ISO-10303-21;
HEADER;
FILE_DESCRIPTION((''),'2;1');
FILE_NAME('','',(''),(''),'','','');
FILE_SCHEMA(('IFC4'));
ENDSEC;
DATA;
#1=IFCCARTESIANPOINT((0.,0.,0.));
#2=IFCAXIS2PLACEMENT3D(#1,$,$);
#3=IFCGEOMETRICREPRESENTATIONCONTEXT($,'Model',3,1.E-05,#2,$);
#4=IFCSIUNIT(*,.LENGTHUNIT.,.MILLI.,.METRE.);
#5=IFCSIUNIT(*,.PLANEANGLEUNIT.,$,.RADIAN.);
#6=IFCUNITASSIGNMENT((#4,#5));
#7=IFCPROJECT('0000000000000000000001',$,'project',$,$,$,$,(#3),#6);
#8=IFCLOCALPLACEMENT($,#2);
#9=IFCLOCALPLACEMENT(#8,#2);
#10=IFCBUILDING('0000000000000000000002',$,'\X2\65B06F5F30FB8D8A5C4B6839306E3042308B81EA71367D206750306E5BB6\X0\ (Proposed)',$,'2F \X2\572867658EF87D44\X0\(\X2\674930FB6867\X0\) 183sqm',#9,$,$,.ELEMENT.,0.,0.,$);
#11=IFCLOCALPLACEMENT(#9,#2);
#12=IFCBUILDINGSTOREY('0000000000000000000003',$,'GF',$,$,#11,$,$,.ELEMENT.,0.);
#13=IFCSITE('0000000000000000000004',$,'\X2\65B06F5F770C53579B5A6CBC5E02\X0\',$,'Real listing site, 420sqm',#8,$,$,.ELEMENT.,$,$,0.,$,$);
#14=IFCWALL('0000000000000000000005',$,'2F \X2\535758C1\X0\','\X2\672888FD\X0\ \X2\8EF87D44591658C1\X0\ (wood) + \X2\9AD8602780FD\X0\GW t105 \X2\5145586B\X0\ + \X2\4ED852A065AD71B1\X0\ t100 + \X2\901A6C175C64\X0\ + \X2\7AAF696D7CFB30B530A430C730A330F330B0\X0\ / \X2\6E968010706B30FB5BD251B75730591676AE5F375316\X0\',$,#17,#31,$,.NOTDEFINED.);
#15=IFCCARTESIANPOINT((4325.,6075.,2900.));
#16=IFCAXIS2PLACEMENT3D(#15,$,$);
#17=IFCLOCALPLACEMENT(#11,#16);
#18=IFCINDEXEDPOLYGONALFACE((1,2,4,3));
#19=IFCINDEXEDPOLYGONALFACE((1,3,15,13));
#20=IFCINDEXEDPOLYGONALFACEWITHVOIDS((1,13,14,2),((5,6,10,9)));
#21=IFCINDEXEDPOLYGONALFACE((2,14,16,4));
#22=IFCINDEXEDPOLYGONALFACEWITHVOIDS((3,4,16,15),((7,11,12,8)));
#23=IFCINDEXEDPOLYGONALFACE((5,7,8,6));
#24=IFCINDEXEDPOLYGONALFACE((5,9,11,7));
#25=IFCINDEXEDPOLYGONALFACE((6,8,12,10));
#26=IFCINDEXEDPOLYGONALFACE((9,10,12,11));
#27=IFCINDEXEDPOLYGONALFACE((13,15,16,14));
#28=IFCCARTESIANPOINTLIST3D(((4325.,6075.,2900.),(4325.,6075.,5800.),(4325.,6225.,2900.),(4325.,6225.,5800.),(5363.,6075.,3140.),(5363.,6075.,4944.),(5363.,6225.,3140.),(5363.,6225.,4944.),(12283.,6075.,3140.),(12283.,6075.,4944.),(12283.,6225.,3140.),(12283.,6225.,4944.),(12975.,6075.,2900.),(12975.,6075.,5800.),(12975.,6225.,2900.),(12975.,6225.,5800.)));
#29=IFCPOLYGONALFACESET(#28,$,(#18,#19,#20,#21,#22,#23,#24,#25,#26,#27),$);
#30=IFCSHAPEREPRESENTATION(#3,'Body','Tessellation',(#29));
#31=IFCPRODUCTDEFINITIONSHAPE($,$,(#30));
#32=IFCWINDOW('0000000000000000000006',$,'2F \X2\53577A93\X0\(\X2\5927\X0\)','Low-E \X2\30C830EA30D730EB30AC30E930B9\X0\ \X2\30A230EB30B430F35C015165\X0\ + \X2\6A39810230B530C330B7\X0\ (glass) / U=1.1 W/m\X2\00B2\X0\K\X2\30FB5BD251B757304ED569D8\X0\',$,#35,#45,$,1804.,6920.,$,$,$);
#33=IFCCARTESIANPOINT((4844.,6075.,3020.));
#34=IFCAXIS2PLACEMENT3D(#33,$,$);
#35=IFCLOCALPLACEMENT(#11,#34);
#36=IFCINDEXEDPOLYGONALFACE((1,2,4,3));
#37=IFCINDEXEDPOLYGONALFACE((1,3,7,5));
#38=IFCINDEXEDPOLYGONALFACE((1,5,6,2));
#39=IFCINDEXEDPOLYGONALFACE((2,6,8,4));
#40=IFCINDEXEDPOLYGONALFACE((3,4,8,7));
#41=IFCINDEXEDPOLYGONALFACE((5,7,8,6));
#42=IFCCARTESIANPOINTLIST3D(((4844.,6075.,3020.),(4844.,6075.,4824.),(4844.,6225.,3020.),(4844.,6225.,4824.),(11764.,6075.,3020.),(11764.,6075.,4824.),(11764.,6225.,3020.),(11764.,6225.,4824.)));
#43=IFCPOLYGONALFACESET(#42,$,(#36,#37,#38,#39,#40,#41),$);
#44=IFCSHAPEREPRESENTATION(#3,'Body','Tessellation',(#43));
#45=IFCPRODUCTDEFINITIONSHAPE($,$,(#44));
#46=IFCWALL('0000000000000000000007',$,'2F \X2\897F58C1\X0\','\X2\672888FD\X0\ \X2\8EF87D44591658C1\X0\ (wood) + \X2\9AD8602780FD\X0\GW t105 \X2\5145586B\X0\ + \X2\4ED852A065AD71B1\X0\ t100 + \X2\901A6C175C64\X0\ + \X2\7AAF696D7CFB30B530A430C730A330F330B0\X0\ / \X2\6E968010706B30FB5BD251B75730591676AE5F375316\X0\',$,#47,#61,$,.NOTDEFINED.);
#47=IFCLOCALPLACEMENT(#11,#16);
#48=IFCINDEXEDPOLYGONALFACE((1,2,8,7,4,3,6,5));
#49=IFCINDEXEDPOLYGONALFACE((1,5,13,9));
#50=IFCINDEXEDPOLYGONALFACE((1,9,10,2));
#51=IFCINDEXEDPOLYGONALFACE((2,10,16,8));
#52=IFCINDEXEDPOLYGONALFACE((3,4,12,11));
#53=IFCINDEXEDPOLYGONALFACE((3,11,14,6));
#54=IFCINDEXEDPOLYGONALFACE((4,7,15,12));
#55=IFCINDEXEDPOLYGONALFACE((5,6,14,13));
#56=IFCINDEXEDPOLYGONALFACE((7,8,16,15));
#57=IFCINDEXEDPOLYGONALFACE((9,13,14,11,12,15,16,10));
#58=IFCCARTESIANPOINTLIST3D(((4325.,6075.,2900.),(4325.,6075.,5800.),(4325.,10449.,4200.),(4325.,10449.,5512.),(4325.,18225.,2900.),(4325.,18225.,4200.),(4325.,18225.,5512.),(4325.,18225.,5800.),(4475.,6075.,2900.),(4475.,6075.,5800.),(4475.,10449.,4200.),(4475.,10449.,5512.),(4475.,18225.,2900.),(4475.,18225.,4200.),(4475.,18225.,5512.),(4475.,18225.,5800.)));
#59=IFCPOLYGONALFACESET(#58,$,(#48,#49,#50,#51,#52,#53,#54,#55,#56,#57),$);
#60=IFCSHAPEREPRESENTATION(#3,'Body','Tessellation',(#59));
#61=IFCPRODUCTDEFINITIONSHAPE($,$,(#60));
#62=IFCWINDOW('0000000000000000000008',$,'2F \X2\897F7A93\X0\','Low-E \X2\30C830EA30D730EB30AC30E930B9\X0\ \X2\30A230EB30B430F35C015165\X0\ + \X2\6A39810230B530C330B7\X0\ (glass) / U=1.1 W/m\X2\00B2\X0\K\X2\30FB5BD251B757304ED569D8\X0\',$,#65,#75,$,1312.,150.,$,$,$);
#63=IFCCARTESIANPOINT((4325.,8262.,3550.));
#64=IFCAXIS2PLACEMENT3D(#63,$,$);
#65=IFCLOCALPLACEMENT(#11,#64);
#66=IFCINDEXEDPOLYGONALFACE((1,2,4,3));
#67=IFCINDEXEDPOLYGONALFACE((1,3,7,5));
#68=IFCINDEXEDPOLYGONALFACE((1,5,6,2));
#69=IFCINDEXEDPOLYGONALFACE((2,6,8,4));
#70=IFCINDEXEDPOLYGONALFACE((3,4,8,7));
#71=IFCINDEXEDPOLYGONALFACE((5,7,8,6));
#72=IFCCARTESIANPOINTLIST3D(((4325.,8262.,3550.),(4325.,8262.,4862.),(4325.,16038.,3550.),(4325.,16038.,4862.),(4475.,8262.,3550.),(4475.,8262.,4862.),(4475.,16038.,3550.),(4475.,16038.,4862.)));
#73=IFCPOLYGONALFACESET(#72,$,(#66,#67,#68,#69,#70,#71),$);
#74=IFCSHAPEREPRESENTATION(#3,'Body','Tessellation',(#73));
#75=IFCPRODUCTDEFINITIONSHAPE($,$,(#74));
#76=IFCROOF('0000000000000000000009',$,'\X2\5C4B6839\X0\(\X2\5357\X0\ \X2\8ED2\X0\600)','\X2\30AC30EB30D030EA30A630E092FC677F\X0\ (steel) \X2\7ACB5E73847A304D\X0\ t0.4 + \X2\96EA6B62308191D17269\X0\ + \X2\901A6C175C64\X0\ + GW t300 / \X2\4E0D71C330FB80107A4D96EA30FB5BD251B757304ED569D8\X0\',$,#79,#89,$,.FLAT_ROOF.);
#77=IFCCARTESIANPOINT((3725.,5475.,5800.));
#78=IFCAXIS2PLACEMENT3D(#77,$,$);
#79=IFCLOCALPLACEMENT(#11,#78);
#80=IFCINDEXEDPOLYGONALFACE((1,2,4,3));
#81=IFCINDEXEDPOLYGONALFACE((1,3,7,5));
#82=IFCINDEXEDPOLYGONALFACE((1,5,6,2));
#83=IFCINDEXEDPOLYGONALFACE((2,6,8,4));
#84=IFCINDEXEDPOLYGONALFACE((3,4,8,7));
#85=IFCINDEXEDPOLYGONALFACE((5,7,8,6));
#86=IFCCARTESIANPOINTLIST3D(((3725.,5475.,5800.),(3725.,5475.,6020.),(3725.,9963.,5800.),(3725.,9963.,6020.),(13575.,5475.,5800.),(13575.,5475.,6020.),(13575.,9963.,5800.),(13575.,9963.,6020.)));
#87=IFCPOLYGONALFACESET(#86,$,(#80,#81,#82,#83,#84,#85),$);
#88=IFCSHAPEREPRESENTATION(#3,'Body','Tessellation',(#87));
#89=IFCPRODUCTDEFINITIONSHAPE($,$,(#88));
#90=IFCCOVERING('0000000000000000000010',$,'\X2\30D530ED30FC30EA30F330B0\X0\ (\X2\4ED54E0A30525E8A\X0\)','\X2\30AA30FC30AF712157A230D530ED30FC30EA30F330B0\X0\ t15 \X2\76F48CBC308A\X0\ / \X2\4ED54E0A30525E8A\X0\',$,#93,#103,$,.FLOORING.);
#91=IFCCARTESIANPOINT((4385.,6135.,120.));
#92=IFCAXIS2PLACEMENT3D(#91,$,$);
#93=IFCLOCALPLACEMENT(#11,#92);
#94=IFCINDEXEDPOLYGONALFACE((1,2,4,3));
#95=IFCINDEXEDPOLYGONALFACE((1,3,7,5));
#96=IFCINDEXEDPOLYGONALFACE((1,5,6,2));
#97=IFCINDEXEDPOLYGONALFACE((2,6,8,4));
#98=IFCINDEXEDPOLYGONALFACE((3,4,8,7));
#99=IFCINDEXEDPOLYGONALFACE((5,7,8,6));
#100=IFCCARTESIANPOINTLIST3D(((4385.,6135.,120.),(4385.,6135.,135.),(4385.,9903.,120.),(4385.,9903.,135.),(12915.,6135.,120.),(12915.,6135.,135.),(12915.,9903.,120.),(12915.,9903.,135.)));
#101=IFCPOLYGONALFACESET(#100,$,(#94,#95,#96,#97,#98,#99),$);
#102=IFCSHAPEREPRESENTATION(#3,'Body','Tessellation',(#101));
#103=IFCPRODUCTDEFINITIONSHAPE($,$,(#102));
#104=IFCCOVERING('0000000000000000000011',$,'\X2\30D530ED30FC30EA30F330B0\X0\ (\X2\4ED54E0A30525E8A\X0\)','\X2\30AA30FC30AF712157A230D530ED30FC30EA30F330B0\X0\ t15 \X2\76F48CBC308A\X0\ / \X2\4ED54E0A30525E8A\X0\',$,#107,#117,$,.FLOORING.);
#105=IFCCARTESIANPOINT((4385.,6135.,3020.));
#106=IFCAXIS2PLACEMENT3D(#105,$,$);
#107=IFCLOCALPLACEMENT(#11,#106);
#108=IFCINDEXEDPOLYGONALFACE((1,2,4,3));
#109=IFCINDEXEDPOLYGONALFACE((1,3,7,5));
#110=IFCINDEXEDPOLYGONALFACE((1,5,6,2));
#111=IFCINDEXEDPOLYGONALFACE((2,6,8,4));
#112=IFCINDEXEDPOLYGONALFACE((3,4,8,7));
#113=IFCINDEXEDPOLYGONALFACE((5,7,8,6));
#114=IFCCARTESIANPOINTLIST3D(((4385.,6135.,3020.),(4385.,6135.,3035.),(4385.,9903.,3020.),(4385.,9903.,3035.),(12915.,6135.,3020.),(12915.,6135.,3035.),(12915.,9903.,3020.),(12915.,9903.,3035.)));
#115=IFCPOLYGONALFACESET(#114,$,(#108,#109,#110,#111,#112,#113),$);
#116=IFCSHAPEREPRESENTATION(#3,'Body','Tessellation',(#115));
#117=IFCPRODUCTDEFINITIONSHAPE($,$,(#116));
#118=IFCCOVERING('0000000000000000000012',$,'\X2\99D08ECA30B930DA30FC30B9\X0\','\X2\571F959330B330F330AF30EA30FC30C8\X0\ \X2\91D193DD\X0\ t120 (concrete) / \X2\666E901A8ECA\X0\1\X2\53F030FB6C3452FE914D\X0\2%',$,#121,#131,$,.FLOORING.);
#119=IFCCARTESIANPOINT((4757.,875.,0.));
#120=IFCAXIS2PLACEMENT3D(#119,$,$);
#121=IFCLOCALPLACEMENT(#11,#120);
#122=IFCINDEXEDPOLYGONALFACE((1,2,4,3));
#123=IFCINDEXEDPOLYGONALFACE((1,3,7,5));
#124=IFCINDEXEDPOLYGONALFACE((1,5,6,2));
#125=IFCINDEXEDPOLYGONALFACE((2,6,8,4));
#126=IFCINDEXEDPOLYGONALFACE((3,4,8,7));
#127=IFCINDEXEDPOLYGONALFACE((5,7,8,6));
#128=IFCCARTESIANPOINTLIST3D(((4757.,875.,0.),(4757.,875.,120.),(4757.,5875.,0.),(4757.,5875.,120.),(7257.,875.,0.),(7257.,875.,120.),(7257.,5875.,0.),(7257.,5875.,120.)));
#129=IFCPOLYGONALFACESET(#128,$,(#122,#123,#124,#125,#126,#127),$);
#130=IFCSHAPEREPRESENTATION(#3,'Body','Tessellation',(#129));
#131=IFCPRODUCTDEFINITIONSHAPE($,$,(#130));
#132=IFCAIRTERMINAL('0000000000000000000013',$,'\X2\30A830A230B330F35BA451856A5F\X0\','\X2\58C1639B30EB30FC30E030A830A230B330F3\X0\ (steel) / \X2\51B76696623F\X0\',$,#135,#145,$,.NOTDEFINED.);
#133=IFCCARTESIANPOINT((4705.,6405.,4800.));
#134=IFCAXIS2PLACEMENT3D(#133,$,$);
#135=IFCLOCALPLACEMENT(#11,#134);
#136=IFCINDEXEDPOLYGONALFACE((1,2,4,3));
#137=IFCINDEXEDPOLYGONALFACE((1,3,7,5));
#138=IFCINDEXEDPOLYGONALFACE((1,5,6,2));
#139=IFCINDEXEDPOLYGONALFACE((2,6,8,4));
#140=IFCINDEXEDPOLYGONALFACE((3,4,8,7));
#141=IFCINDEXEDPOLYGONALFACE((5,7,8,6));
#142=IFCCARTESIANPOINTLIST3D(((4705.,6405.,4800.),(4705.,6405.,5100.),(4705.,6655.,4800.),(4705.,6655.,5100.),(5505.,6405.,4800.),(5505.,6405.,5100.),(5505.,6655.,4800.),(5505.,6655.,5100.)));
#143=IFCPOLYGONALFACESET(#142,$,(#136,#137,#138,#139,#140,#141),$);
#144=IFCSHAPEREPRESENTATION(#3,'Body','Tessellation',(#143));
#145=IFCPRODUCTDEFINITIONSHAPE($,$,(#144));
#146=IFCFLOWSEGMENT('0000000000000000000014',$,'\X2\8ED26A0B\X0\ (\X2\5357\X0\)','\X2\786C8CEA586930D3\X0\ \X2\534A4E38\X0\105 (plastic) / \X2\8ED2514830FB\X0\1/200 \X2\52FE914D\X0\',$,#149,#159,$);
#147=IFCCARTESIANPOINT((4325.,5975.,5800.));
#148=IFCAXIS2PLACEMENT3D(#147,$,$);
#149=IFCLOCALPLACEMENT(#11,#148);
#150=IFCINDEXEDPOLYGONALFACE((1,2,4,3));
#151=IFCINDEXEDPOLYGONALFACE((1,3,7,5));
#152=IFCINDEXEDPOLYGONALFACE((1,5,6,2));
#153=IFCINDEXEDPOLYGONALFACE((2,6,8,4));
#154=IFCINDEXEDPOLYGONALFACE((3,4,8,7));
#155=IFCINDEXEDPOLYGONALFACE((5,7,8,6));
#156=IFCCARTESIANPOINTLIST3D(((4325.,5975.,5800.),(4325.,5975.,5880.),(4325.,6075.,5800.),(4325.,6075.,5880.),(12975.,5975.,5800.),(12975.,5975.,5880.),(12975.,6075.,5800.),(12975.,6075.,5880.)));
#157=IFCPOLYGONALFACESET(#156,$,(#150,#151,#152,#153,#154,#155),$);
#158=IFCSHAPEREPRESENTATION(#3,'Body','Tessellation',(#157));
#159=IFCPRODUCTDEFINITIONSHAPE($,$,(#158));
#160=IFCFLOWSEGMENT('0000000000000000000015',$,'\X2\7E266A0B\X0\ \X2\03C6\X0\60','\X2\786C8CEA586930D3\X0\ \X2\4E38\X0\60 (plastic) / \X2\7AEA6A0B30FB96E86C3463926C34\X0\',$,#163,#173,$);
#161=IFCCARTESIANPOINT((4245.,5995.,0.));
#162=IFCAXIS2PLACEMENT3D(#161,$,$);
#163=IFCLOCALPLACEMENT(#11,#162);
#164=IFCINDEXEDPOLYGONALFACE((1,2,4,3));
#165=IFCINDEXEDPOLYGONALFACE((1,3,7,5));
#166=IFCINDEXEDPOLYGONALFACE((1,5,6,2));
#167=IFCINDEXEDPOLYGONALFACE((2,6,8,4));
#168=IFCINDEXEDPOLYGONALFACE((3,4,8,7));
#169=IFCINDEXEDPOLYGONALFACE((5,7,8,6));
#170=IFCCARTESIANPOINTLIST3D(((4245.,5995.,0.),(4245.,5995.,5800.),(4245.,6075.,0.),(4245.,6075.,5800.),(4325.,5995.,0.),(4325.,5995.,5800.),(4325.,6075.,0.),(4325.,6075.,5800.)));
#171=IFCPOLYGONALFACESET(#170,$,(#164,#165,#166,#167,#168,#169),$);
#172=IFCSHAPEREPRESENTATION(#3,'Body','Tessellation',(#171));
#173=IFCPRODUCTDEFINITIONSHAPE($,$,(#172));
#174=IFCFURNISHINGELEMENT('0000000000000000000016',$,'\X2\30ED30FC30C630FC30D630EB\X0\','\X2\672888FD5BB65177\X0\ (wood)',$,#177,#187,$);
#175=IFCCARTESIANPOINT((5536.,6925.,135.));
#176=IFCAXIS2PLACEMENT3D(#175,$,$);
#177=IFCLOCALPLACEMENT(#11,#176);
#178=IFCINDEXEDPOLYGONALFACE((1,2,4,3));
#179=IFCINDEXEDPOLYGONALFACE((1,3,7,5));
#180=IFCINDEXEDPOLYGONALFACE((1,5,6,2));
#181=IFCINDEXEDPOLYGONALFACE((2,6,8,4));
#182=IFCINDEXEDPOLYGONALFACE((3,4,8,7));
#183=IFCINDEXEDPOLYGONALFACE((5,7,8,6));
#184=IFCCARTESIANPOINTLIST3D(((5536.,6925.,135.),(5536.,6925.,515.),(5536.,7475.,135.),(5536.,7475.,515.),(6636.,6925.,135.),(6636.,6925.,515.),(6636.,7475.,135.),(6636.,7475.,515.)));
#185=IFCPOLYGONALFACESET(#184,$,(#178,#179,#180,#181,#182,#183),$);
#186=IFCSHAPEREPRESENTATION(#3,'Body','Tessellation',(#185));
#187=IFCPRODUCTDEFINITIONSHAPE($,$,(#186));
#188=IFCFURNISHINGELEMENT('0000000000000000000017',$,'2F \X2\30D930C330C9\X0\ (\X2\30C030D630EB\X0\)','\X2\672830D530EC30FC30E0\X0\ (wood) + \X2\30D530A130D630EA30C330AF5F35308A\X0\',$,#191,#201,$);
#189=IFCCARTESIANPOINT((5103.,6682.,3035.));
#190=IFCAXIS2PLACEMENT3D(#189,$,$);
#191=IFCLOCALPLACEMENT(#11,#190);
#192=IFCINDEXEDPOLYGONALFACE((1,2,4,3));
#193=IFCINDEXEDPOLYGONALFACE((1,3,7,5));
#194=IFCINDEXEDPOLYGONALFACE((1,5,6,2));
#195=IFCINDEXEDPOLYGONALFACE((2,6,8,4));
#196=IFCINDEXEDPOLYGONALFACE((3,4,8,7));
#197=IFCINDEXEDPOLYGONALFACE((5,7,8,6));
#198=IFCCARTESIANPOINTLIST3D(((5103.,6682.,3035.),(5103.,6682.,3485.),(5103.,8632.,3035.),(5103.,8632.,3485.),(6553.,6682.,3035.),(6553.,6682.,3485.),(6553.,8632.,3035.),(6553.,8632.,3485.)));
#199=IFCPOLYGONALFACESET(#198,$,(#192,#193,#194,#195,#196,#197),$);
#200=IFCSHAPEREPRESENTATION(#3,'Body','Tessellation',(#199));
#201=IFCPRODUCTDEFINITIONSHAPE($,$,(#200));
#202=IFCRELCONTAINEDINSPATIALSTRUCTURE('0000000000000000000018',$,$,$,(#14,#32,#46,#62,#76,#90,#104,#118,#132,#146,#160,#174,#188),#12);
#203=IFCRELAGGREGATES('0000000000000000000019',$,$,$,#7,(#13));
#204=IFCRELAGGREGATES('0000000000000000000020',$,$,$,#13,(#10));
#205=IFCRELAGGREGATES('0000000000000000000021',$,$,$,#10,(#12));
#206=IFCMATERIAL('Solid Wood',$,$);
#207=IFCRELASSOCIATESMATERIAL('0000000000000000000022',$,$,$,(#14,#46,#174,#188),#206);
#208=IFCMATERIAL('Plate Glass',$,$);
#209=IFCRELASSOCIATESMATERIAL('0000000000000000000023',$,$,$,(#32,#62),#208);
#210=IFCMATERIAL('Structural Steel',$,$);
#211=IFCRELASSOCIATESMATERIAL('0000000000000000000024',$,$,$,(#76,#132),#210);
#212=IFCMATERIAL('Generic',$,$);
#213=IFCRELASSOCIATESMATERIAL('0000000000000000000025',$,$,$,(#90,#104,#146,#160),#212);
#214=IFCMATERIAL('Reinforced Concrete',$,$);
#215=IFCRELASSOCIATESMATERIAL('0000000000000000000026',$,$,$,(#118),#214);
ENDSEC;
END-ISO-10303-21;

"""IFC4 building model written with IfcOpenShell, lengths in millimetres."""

from ifc_helpers import new_model, si_unit, frame, frame_2d, origin, place, context, project, spatial, rectangle, extrude, material, element, fill, save


model = new_model("IFC4")

# Units and contexts
model_context = context("Model", 3, precision=1e-05, world=origin())
ifc_project = project(units=[si_unit("LENGTHUNIT", "METRE", prefix="MILLI"), si_unit("PLANEANGLEUNIT", "RADIAN")], contexts=[model_context])

# Site, building, storey
site_placement = place(None, origin())
site = spatial("IfcSite", under=ifc_project, at=site_placement, Name="新潟県南魚沼市", ObjectType="Real listing site, 420sqm", CompositionType="ELEMENT", RefElevation=0.0)
building_placement = place(site_placement, origin())
building = spatial("IfcBuilding", under=site, at=building_placement, Name="新潟・越屋根のある自然素材の家 (Proposed)", ObjectType="2F 在来軸組(杉・桧) 183sqm", CompositionType="ELEMENT", ElevationOfRefHeight=0.0, ElevationOfTerrain=0.0)
storey_placement = place(building_placement, origin())
storey = spatial("IfcBuildingStorey", under=building, at=storey_placement, Name="GF", CompositionType="ELEMENT", Elevation=0.0)

# Shared definitions
ifc_material_1 = material(Name="Solid Wood")

# Shared definitions
ifc_material_2 = material(Name="Reinforced Concrete")

# Shared definitions
ifc_material_3 = material(Name="Plate Glass")

# Walls, openings, windows
wall_1_placement = place(storey_placement, frame((4325.0, 6075.0, 2900.0)))
wall_1 = element("IfcWall", 1, at=wall_1_placement, inside=storey, material=ifc_material_1, Name="2F 南壁", Description="木製 軸組外壁 (wood) + 高性能GW t105 充填 + 付加断熱 t100 + 通気層 + 窯業系サイディング / 準耐火・寒冷地外皮強化", PredefinedType="NOTDEFINED", context=model_context, shape_type="SweptSolid", body=[
    extrude(rectangle(XDim=8650.0, YDim=150.0, at=frame_2d((4325.0, 75.0))), frame((4325.0, 6075.0, 2900.0)), (0.0, 0.0, 1.0), 2900.0),
])
opening_1_placement = place(storey_placement, frame((4844.0, 6075.0, 3020.0)))
opening_1 = element("IfcOpeningElement", 2, at=opening_1_placement, cuts=wall_1, PredefinedType="NOTDEFINED", context=model_context, shape_type="SweptSolid", body=[
    extrude(rectangle(XDim=6920.0, YDim=150.0, at=frame_2d((3460.0, 75.0))), frame((4844.0, 6075.0, 3020.0)), (0.0, 0.0, 1.0), 1804.0),
])
window_1_placement = place(storey_placement, frame((4844.0, 6075.0, 3020.0)))
window_1 = element("IfcWindow", 3, at=window_1_placement, inside=storey, material=ifc_material_3, Name="2F 南窓(大)", Description="Low-E トリプルガラス アルゴン封入 + 樹脂サッシ (glass) / U=1.1 W/m²K・寒冷地仕様", OverallHeight=1804.0, OverallWidth=6920.0, context=model_context, shape_type="SweptSolid", body=[
    extrude(rectangle(XDim=6920.0, YDim=150.0, at=frame_2d((3460.0, 75.0))), frame((4844.0, 6075.0, 3020.0)), (0.0, 0.0, 1.0), 1804.0),
])
fill(opening_1, window_1)
wall_2_placement = place(storey_placement, frame((4325.0, 6075.0, 2900.0)))
wall_2 = element("IfcWall", 4, at=wall_2_placement, inside=storey, material=ifc_material_1, Name="2F 西壁", Description="木製 軸組外壁 (wood) + 高性能GW t105 充填 + 付加断熱 t100 + 通気層 + 窯業系サイディング / 準耐火・寒冷地外皮強化", PredefinedType="NOTDEFINED", context=model_context, shape_type="SweptSolid", body=[
    extrude(rectangle(XDim=150.0, YDim=12150.0, at=frame_2d((75.0, 6075.0))), frame((4325.0, 6075.0, 2900.0)), (0.0, 0.0, 1.0), 2900.0),
])
opening_2_placement = place(storey_placement, frame((4325.0, 8262.0, 3550.0)))
opening_2 = element("IfcOpeningElement", 5, at=opening_2_placement, cuts=wall_2, PredefinedType="NOTDEFINED", context=model_context, shape_type="SweptSolid", body=[
    extrude(rectangle(XDim=150.0, YDim=7776.0, at=frame_2d((75.0, 3888.0))), frame((4325.0, 8262.0, 3550.0)), (0.0, 0.0, 1.0), 1312.0),
])
window_2_placement = place(storey_placement, frame((4325.0, 8262.0, 3550.0)))
window_2 = element("IfcWindow", 6, at=window_2_placement, inside=storey, material=ifc_material_3, Name="2F 西窓", Description="Low-E トリプルガラス アルゴン封入 + 樹脂サッシ (glass) / U=1.1 W/m²K・寒冷地仕様", OverallHeight=1312.0, OverallWidth=150.0, context=model_context, shape_type="SweptSolid", body=[
    extrude(rectangle(XDim=150.0, YDim=7776.0, at=frame_2d((75.0, 3888.0))), frame((4325.0, 8262.0, 3550.0)), (0.0, 0.0, 1.0), 1312.0),
])
fill(opening_2, window_2)

# Roof
ifc_material_4 = material(Name="Structural Steel")
for number, where, name in (
    (7, (3725.0, 5475.0, 5800.0), "屋根(南 軒600)"),
):
    element("IfcRoof", number, at=place(storey_placement, frame(where)), inside=storey, material=ifc_material_4, Name=name, Description="ガルバリウム鋼板 (steel) 立平葺き t0.4 + 雪止め金物 + 通気層 + GW t300 / 不燃・耐積雪・寒冷地仕様", PredefinedType="FLAT_ROOF", context=model_context, shape_type="SweptSolid", body=[
        extrude(rectangle(XDim=9850.0, YDim=4488.0, at=frame_2d((4925.0, 2244.0))), frame((3725.0, 5475.0, 5800.0)), (0.0, 0.0, 1.0), 220.0),
    ])

# Coverings
ifc_material_5 = material(Name="Generic")
covering_1_placement = place(storey_placement, frame((4385.0, 6135.0, 120.0)))
element("IfcCovering", 8, at=covering_1_placement, inside=storey, material=ifc_material_5, Name="フローリング (仕上げ床)", Description="オーク無垢フローリング t15 直貼り / 仕上げ床", PredefinedType="FLOORING", context=model_context, shape_type="SweptSolid", body=[
    extrude(rectangle(XDim=8530.0, YDim=3768.0, at=frame_2d((4265.0, 1884.0))), frame((4385.0, 6135.0, 120.0)), (0.0, 0.0, 1.0), 15.0),
])
covering_2_placement = place(storey_placement, frame((4385.0, 6135.0, 3020.0)))
element("IfcCovering", 9, at=covering_2_placement, inside=storey, material=ifc_material_5, Name="フローリング (仕上げ床)", Description="オーク無垢フローリング t15 直貼り / 仕上げ床", PredefinedType="FLOORING", context=model_context, shape_type="SweptSolid", body=[
    extrude(rectangle(XDim=8530.0, YDim=3768.0, at=frame_2d((4265.0, 1884.0))), frame((4385.0, 6135.0, 3020.0)), (0.0, 0.0, 1.0), 15.0),
])
covering_3_placement = place(storey_placement, frame((4757.0, 875.0, 0.0)))
element("IfcCovering", 10, at=covering_3_placement, inside=storey, material=ifc_material_2, Name="駐車スペース", Description="土間コンクリート 金鏝 t120 (concrete) / 普通車1台・水勾配2%", PredefinedType="FLOORING", context=model_context, shape_type="SweptSolid", body=[
    extrude(rectangle(XDim=2500.0, YDim=5000.0, at=frame_2d((1250.0, 2500.0))), frame((4757.0, 875.0, 0.0)), (0.0, 0.0, 1.0), 120.0),
])

# Air terminal
air_terminal_placement = place(storey_placement, frame((4705.0, 6405.0, 4800.0)))
element("IfcAirTerminal", 11, at=air_terminal_placement, inside=storey, material=ifc_material_4, Name="エアコン室内機", Description="壁掛ルームエアコン (steel) / 冷暖房", PredefinedType="NOTDEFINED", context=model_context, shape_type="SweptSolid", body=[
    extrude(rectangle(XDim=800.0, YDim=250.0, at=frame_2d((400.0, 125.0))), frame((4705.0, 6405.0, 4800.0)), (0.0, 0.0, 1.0), 300.0),
])

# Flow segments
flow_segment_1_placement = place(storey_placement, frame((4325.0, 5975.0, 5800.0)))
element("IfcFlowSegment", 12, at=flow_segment_1_placement, inside=storey, material=ifc_material_5, Name="軒樋 (南)", Description="硬質塩ビ 半丸105 (plastic) / 軒先・1/200 勾配", context=model_context, shape_type="SweptSolid", body=[
    extrude(rectangle(XDim=8650.0, YDim=100.0, at=frame_2d((4325.0, 50.0))), frame((4325.0, 5975.0, 5800.0)), (0.0, 0.0, 1.0), 80.0),
])
flow_segment_2_placement = place(storey_placement, frame((4245.0, 5995.0, 0.0)))
element("IfcFlowSegment", 13, at=flow_segment_2_placement, inside=storey, material=ifc_material_5, Name="縦樋 φ60", Description="硬質塩ビ 丸60 (plastic) / 竪樋・雨水排水", context=model_context, shape_type="SweptSolid", body=[
    extrude(rectangle(XDim=80.0, YDim=80.0, at=frame_2d((40.0, 40.0))), frame((4245.0, 5995.0, 0.0)), (0.0, 0.0, 1.0), 5800.0),
])

# Furnishing elements
furnishing_1_placement = place(storey_placement, frame((5536.0, 6925.0, 135.0)))
element("IfcFurnishingElement", 14, at=furnishing_1_placement, inside=storey, material=ifc_material_1, Name="ローテーブル", Description="木製家具 (wood)", context=model_context, shape_type="SweptSolid", body=[
    extrude(rectangle(XDim=1100.0, YDim=550.0, at=frame_2d((550.0, 275.0))), frame((5536.0, 6925.0, 135.0)), (0.0, 0.0, 1.0), 380.0),
])
furnishing_2_placement = place(storey_placement, frame((5103.0, 6682.0, 3035.0)))
element("IfcFurnishingElement", 15, at=furnishing_2_placement, inside=storey, material=ifc_material_1, Name="2F ベッド (ダブル)", Description="木フレーム (wood) + ファブリック張り", context=model_context, shape_type="SweptSolid", body=[
    extrude(rectangle(XDim=1450.0, YDim=1950.0, at=frame_2d((725.0, 975.0))), frame((5103.0, 6682.0, 3035.0)), (0.0, 0.0, 1.0), 450.0),
])

save(model, "model.ifc")
